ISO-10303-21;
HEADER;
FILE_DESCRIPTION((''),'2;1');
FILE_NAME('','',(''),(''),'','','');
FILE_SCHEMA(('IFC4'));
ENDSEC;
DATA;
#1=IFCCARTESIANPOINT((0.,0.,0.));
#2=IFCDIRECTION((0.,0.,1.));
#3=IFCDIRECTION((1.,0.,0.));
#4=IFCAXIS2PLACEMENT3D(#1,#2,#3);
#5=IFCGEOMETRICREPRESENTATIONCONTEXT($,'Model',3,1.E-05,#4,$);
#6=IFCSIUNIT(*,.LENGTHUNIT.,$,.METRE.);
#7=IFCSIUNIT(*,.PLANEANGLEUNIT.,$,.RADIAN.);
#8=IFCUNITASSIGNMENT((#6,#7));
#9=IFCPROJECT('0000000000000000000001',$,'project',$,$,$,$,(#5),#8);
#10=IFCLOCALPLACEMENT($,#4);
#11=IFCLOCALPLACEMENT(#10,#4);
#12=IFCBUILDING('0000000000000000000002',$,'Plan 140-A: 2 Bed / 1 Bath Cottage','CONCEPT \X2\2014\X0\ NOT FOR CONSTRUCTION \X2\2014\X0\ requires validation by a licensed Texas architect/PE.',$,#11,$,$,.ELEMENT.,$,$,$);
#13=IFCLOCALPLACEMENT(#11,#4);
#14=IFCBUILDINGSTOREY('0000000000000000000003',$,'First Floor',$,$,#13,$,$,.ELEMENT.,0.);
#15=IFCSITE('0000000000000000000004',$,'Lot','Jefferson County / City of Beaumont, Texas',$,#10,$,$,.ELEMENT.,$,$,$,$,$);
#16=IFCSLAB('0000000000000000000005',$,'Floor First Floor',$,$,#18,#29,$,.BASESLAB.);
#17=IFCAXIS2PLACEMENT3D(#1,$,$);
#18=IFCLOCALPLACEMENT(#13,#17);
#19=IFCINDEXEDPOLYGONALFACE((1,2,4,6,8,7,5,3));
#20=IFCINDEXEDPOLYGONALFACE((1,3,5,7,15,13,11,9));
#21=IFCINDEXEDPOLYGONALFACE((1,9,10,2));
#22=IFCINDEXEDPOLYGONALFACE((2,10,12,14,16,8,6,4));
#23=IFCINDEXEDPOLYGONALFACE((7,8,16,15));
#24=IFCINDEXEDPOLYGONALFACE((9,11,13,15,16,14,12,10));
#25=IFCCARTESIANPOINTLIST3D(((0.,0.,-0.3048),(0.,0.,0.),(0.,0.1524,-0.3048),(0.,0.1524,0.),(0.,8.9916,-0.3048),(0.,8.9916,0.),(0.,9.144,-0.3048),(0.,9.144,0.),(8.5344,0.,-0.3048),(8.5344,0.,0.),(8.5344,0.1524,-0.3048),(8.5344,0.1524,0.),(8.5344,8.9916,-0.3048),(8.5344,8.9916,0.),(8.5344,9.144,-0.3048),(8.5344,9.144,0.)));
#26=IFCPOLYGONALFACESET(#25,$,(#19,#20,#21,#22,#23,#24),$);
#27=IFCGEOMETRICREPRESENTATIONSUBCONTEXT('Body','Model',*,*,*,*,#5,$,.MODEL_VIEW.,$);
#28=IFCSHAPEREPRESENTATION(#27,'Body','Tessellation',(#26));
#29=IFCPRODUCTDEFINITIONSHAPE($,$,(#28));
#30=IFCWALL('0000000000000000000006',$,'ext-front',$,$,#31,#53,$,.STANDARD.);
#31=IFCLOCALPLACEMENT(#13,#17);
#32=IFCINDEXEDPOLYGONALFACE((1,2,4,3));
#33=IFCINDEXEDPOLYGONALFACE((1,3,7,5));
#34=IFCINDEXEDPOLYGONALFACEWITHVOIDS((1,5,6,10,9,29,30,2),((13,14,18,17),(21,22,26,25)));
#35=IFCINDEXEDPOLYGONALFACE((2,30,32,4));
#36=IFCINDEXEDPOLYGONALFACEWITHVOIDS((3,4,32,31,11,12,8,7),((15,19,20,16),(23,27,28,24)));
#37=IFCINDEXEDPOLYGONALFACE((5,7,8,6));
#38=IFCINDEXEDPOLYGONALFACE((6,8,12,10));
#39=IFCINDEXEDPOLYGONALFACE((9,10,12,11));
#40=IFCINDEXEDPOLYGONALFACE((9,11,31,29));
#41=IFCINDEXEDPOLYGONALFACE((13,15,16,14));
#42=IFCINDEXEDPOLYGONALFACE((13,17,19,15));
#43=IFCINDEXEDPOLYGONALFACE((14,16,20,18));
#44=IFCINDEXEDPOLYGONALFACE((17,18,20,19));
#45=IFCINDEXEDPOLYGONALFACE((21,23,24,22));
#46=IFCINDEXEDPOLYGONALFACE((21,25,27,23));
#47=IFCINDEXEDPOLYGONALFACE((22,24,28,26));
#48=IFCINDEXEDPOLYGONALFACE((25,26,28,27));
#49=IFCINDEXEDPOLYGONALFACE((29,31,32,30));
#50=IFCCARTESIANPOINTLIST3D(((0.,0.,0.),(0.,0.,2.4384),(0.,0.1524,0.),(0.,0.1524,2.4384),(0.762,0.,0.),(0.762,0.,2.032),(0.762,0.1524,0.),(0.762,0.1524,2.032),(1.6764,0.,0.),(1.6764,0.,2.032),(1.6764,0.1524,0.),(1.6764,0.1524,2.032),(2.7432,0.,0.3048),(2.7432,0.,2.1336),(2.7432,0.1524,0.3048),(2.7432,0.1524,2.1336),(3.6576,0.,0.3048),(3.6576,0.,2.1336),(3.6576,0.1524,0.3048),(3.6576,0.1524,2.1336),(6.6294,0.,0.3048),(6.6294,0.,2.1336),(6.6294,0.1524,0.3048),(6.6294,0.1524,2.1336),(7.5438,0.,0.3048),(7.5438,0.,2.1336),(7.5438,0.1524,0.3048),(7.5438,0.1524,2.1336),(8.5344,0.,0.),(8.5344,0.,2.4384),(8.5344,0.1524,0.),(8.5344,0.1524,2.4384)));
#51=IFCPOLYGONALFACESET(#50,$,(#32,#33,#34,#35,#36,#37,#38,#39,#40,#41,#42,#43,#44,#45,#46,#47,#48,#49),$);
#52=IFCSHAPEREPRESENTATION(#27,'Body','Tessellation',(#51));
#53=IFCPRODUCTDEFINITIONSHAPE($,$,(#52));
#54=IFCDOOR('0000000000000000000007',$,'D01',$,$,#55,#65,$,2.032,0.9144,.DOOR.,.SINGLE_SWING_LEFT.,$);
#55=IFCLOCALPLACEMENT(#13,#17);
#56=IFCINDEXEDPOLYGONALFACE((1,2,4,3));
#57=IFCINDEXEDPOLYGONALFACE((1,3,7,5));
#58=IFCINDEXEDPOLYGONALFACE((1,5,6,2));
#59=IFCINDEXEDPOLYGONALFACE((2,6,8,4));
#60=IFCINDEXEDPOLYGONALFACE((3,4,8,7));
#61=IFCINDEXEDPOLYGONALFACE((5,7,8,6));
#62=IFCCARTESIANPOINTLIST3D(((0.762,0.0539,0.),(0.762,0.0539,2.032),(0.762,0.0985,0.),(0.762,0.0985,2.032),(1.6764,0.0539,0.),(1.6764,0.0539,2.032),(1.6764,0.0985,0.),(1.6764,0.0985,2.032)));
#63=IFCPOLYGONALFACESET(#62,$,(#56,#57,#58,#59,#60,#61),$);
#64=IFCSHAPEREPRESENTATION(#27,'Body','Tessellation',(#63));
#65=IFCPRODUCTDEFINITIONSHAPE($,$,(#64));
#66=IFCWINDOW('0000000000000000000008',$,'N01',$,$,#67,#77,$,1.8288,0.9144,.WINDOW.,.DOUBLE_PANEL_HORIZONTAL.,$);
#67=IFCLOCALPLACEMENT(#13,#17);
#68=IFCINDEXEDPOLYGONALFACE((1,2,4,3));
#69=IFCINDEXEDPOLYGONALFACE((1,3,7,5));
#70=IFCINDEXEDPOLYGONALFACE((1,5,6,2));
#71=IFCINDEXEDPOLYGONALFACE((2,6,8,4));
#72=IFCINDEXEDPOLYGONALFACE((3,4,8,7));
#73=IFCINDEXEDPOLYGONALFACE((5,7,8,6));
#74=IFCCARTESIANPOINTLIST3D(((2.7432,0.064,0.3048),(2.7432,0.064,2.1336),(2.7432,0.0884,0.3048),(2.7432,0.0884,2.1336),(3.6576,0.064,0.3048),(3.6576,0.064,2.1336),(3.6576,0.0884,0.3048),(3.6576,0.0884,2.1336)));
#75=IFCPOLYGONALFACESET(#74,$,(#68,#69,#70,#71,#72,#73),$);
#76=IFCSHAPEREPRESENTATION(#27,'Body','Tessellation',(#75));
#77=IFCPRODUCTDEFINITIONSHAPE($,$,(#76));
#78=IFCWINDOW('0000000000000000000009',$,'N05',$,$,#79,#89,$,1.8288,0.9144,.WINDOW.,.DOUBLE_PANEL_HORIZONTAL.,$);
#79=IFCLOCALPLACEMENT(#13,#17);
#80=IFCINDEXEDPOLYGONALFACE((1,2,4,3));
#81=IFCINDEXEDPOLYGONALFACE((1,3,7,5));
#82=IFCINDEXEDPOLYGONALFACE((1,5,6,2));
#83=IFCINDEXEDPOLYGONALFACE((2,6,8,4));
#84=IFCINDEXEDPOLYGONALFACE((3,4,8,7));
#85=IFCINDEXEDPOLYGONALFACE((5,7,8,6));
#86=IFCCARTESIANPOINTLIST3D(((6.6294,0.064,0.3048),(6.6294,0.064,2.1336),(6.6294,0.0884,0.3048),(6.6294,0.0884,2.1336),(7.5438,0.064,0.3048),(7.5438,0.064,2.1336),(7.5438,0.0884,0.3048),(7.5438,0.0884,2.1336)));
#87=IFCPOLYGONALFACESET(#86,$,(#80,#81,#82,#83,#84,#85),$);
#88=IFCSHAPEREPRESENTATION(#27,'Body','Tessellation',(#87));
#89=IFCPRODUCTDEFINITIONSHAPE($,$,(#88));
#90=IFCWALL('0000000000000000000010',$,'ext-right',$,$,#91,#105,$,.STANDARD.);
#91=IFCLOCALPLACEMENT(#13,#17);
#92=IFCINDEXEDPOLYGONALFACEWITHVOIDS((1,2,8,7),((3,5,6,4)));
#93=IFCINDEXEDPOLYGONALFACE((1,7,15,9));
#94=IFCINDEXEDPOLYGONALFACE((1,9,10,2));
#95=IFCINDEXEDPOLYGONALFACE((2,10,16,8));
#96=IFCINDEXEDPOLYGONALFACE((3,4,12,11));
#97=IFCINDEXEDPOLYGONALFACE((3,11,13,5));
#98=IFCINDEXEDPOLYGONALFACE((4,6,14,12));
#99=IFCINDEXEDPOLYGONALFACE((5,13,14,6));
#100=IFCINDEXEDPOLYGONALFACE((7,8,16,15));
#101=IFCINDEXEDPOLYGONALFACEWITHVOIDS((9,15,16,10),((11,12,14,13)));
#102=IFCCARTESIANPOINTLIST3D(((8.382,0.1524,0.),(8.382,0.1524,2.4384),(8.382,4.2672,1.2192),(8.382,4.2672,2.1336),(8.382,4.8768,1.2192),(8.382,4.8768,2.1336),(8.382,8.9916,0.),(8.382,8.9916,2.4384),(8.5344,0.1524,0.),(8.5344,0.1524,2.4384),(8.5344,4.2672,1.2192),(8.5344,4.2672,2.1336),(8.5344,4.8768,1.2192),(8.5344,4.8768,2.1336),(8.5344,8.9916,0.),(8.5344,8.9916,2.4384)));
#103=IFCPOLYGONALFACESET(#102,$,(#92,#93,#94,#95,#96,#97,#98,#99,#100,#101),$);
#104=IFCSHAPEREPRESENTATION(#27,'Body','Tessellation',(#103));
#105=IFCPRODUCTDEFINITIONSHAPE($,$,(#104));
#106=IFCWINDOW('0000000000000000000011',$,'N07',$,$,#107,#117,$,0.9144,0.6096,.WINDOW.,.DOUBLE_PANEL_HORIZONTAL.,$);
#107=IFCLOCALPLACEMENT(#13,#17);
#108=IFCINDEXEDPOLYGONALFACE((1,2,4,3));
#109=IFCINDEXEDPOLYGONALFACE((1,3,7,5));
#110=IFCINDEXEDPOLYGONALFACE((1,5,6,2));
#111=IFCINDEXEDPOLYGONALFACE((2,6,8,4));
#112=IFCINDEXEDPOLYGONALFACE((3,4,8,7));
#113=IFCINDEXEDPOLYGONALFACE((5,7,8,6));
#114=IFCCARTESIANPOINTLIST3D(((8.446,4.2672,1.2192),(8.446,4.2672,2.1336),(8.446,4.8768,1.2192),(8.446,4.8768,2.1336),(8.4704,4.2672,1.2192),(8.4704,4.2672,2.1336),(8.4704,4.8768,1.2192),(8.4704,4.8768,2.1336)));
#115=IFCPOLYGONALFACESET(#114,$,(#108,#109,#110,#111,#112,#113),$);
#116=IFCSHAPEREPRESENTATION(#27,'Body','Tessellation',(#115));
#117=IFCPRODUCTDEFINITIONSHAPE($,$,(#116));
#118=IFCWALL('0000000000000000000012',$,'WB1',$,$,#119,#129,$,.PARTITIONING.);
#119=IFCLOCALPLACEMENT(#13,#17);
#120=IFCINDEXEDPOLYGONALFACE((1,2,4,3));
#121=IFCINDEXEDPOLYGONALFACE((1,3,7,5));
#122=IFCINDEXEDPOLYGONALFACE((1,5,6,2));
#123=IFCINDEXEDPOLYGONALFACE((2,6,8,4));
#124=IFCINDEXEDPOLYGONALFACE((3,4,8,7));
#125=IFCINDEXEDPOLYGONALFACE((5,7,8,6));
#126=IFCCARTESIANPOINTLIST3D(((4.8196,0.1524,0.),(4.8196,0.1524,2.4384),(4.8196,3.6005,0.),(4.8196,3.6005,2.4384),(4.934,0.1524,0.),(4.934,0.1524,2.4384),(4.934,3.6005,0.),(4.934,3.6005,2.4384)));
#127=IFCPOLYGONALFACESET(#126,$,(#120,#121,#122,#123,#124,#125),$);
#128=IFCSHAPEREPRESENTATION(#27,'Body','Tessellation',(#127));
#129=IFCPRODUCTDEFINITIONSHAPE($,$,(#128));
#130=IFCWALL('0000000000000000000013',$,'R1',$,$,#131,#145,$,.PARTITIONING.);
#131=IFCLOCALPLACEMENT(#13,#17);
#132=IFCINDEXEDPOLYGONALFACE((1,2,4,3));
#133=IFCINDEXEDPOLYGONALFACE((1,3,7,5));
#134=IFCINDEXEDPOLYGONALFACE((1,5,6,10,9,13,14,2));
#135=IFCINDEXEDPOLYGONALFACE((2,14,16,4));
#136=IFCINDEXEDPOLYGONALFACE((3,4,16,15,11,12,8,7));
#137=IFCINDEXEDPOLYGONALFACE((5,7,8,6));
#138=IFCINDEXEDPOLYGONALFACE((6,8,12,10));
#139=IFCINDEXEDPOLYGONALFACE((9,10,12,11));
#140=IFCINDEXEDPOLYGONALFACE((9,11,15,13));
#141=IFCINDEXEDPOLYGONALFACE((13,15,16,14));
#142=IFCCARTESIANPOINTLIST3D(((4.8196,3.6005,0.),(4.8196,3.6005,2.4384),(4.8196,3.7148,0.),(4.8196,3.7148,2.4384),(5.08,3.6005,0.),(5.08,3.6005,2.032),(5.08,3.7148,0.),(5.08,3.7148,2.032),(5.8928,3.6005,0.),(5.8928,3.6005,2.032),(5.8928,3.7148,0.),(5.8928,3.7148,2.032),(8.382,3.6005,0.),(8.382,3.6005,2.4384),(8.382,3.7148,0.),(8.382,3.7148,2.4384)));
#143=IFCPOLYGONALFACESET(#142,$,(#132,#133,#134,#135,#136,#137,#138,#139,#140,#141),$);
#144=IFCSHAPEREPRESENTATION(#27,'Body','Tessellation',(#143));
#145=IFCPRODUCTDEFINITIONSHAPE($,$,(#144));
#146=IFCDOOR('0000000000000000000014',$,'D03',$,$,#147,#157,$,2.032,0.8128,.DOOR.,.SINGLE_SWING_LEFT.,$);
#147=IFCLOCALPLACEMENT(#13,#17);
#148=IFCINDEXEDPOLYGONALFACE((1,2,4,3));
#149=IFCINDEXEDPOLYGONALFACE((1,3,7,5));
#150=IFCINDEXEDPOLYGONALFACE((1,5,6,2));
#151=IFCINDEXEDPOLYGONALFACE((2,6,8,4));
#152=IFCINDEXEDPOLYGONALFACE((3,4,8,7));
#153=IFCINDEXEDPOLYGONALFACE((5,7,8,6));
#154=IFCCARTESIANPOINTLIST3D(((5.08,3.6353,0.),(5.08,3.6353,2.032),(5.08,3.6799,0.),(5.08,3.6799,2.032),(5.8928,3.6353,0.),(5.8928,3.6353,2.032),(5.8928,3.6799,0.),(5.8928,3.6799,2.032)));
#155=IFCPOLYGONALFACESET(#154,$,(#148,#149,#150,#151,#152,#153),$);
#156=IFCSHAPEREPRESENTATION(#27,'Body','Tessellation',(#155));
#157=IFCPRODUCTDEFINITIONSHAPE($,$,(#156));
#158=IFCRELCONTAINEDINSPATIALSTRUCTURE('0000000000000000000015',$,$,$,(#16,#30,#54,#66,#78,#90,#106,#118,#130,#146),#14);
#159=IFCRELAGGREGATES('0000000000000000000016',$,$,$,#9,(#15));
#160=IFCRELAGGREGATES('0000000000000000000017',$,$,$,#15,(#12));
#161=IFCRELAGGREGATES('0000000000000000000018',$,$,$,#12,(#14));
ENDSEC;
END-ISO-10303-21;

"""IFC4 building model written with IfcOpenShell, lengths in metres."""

from ifc_helpers import new_model, si_unit, frame, frame_2d, origin_with_axes, place, context, subcontext, project, spatial, polyline, rectangle, outline, extrude, element, fill, save


model = new_model("IFC4")

# Units and contexts
model_context = context("Model", 3, precision=1e-05, world=origin_with_axes())
body_context = subcontext(model_context, "Body", "Model", "MODEL_VIEW")
ifc_project = project(units=[si_unit("LENGTHUNIT", "METRE"), si_unit("PLANEANGLEUNIT", "RADIAN")], contexts=[model_context])

# Site, building, storey
site_placement = place(None, origin_with_axes())
site = spatial("IfcSite", under=ifc_project, at=site_placement, Name="Lot", Description="Jefferson County / City of Beaumont, Texas", CompositionType="ELEMENT")
building_placement = place(site_placement, origin_with_axes())
building = spatial("IfcBuilding", under=site, at=building_placement, Name="Plan 140-A: 2 Bed / 1 Bath Cottage", Description="CONCEPT — NOT FOR CONSTRUCTION — requires validation by a licensed Texas architect/PE.", CompositionType="ELEMENT")
storey_placement = place(building_placement, origin_with_axes())
storey = spatial("IfcBuildingStorey", under=building, at=storey_placement, Name="First Floor", CompositionType="ELEMENT", Elevation=0.0)

# Slab
slab_placement = place(storey_placement, frame((0.0, 0.0, -0.3048), z_axis=(0.0, 0.0, 1.0), x_axis=(1.0, 0.0, 0.0)))
element("IfcSlab", 1, at=slab_placement, inside=storey, Name="Floor First Floor", PredefinedType="BASESLAB", context=body_context, shape_type="SweptSolid", body=[
    extrude(outline(polyline([(8.5344, 9.144), (8.5344, 8.9916), (8.5344, 0.1524), (8.5344, 0.0), (0.0, 0.0), (0.0, 0.1524), (0.0, 8.9916), (0.0, 9.144), (8.5344, 9.144)])), origin_with_axes(), (0.0, 0.0, 1.0), 0.3048),
])

# Wall, openings, door, windows
wall_1_placement = place(storey_placement, frame((0.0, 0.0762, 0.0), z_axis=(0.0, 0.0, 1.0), x_axis=(1.0, 0.0, 0.0)))
wall_1 = element("IfcWall", 2, at=wall_1_placement, inside=storey, Name="ext-front", PredefinedType="STANDARD", context=body_context, shape_type="SweptSolid", body=[
    extrude(rectangle(XDim=8.5344, YDim=0.1524, at=frame_2d((4.2672, 0.0), x_axis=(1.0, 0.0))), origin_with_axes(), (0.0, 0.0, 1.0), 2.4384),
])
opening_1_placement = place(wall_1_placement, frame((0.762, 0.0, 0.0), z_axis=(0.0, 0.0, 1.0), x_axis=(1.0, 0.0, 0.0)))
opening_1 = element("IfcOpeningElement", 3, at=opening_1_placement, cuts=wall_1, PredefinedType="OPENING", context=body_context, shape_type="SweptSolid", body=[
    extrude(rectangle(XDim=0.9144, YDim=0.1829, at=frame_2d((0.4572, 0.0), x_axis=(1.0, 0.0))), origin_with_axes(), (0.0, 0.0, 1.0), 2.032),
])
opening_2_placement = place(wall_1_placement, frame((2.7432, 0.0, 0.3048), z_axis=(0.0, 0.0, 1.0), x_axis=(1.0, 0.0, 0.0)))
opening_2 = element("IfcOpeningElement", 4, at=opening_2_placement, cuts=wall_1, PredefinedType="OPENING", context=body_context, shape_type="SweptSolid", body=[
    extrude(rectangle(XDim=0.9144, YDim=0.1829, at=frame_2d((0.4572, 0.0), x_axis=(1.0, 0.0))), origin_with_axes(), (0.0, 0.0, 1.0), 1.8288),
])
opening_3_placement = place(wall_1_placement, frame((6.6294, 0.0, 0.3048), z_axis=(0.0, 0.0, 1.0), x_axis=(1.0, 0.0, 0.0)))
opening_3 = element("IfcOpeningElement", 5, at=opening_3_placement, cuts=wall_1, PredefinedType="OPENING", context=body_context, shape_type="SweptSolid", body=[
    extrude(rectangle(XDim=0.9144, YDim=0.1829, at=frame_2d((0.4572, 0.0), x_axis=(1.0, 0.0))), origin_with_axes(), (0.0, 0.0, 1.0), 1.8288),
])
door_1_placement = place(opening_1_placement, origin_with_axes())
door_1 = element("IfcDoor", 6, at=door_1_placement, inside=storey, Name="D01", OperationType="SINGLE_SWING_LEFT", OverallHeight=2.032, OverallWidth=0.9144, PredefinedType="DOOR", context=body_context, shape_type="SweptSolid", body=[
    extrude(rectangle(XDim=0.9144, YDim=0.0445, at=frame_2d((0.4572, 0.0), x_axis=(1.0, 0.0))), origin_with_axes(), (0.0, 0.0, 1.0), 2.032),
])
fill(opening_1, door_1)
window_1_placement = place(opening_2_placement, origin_with_axes())
window_1 = element("IfcWindow", 7, at=window_1_placement, inside=storey, Name="N01", OverallHeight=1.8288, OverallWidth=0.9144, PartitioningType="DOUBLE_PANEL_HORIZONTAL", PredefinedType="WINDOW", context=body_context, shape_type="SweptSolid", body=[
    extrude(rectangle(XDim=0.9144, YDim=0.0244, at=frame_2d((0.4572, 0.0), x_axis=(1.0, 0.0))), origin_with_axes(), (0.0, 0.0, 1.0), 1.8288),
])
fill(opening_2, window_1)
window_2_placement = place(opening_3_placement, origin_with_axes())
window_2 = element("IfcWindow", 8, at=window_2_placement, inside=storey, Name="N05", OverallHeight=1.8288, OverallWidth=0.9144, PartitioningType="DOUBLE_PANEL_HORIZONTAL", PredefinedType="WINDOW", context=body_context, shape_type="SweptSolid", body=[
    extrude(rectangle(XDim=0.9144, YDim=0.0244, at=frame_2d((0.4572, 0.0), x_axis=(1.0, 0.0))), origin_with_axes(), (0.0, 0.0, 1.0), 1.8288),
])
fill(opening_3, window_2)

# Wall, opening, window
wall_2_placement = place(storey_placement, frame((8.4582, 0.1524, 0.0), z_axis=(0.0, 0.0, 1.0), x_axis=(0.0, 1.0, 0.0)))
wall_2 = element("IfcWall", 9, at=wall_2_placement, inside=storey, Name="ext-right", PredefinedType="STANDARD", context=body_context, shape_type="SweptSolid", body=[
    extrude(rectangle(XDim=8.8392, YDim=0.1524, at=frame_2d((4.4196, 0.0), x_axis=(1.0, 0.0))), origin_with_axes(), (0.0, 0.0, 1.0), 2.4384),
])
opening_4_placement = place(wall_2_placement, frame((4.1148, 0.0, 1.2192), z_axis=(0.0, 0.0, 1.0), x_axis=(1.0, 0.0, 0.0)))
opening_4 = element("IfcOpeningElement", 10, at=opening_4_placement, cuts=wall_2, PredefinedType="OPENING", context=body_context, shape_type="SweptSolid", body=[
    extrude(rectangle(XDim=0.6096, YDim=0.1829, at=frame_2d((0.3048, 0.0), x_axis=(1.0, 0.0))), origin_with_axes(), (0.0, 0.0, 1.0), 0.9144),
])
window_3_placement = place(opening_4_placement, origin_with_axes())
window_3 = element("IfcWindow", 11, at=window_3_placement, inside=storey, Name="N07", OverallHeight=0.9144, OverallWidth=0.6096, PartitioningType="DOUBLE_PANEL_HORIZONTAL", PredefinedType="WINDOW", context=body_context, shape_type="SweptSolid", body=[
    extrude(rectangle(XDim=0.6096, YDim=0.0244, at=frame_2d((0.3048, 0.0), x_axis=(1.0, 0.0))), origin_with_axes(), (0.0, 0.0, 1.0), 0.9144),
])
fill(opening_4, window_3)

# Wall
wall_3_placement = place(storey_placement, frame((4.8768, 0.1524, 0.0), z_axis=(0.0, 0.0, 1.0), x_axis=(0.0, 1.0, 0.0)))
element("IfcWall", 12, at=wall_3_placement, inside=storey, Name="WB1", PredefinedType="PARTITIONING", context=body_context, shape_type="SweptSolid", body=[
    extrude(rectangle(XDim=3.4481, YDim=0.1143, at=frame_2d((1.724, 0.0), x_axis=(1.0, 0.0))), origin_with_axes(), (0.0, 0.0, 1.0), 2.4384),
])

# Wall, opening, door
wall_4_placement = place(storey_placement, frame((4.8197, 3.6576, 0.0), z_axis=(0.0, 0.0, 1.0), x_axis=(1.0, 0.0, 0.0)))
wall_4 = element("IfcWall", 13, at=wall_4_placement, inside=storey, Name="R1", PredefinedType="PARTITIONING", context=body_context, shape_type="SweptSolid", body=[
    extrude(rectangle(XDim=3.5624, YDim=0.1143, at=frame_2d((1.7812, 0.0), x_axis=(1.0, 0.0))), origin_with_axes(), (0.0, 0.0, 1.0), 2.4384),
])
opening_5_placement = place(wall_4_placement, frame((0.2603, 0.0, 0.0), z_axis=(0.0, 0.0, 1.0), x_axis=(1.0, 0.0, 0.0)))
opening_5 = element("IfcOpeningElement", 14, at=opening_5_placement, cuts=wall_4, PredefinedType="OPENING", context=body_context, shape_type="SweptSolid", body=[
    extrude(rectangle(XDim=0.8128, YDim=0.1448, at=frame_2d((0.4064, 0.0), x_axis=(1.0, 0.0))), origin_with_axes(), (0.0, 0.0, 1.0), 2.032),
])
door_2_placement = place(opening_5_placement, origin_with_axes())
door_2 = element("IfcDoor", 15, at=door_2_placement, inside=storey, Name="D03", OperationType="SINGLE_SWING_LEFT", OverallHeight=2.032, OverallWidth=0.8128, PredefinedType="DOOR", context=body_context, shape_type="SweptSolid", body=[
    extrude(rectangle(XDim=0.8128, YDim=0.0445, at=frame_2d((0.4064, 0.0), x_axis=(1.0, 0.0))), origin_with_axes(), (0.0, 0.0, 1.0), 2.032),
])
fill(opening_5, door_2)

save(model, "model.ifc")
